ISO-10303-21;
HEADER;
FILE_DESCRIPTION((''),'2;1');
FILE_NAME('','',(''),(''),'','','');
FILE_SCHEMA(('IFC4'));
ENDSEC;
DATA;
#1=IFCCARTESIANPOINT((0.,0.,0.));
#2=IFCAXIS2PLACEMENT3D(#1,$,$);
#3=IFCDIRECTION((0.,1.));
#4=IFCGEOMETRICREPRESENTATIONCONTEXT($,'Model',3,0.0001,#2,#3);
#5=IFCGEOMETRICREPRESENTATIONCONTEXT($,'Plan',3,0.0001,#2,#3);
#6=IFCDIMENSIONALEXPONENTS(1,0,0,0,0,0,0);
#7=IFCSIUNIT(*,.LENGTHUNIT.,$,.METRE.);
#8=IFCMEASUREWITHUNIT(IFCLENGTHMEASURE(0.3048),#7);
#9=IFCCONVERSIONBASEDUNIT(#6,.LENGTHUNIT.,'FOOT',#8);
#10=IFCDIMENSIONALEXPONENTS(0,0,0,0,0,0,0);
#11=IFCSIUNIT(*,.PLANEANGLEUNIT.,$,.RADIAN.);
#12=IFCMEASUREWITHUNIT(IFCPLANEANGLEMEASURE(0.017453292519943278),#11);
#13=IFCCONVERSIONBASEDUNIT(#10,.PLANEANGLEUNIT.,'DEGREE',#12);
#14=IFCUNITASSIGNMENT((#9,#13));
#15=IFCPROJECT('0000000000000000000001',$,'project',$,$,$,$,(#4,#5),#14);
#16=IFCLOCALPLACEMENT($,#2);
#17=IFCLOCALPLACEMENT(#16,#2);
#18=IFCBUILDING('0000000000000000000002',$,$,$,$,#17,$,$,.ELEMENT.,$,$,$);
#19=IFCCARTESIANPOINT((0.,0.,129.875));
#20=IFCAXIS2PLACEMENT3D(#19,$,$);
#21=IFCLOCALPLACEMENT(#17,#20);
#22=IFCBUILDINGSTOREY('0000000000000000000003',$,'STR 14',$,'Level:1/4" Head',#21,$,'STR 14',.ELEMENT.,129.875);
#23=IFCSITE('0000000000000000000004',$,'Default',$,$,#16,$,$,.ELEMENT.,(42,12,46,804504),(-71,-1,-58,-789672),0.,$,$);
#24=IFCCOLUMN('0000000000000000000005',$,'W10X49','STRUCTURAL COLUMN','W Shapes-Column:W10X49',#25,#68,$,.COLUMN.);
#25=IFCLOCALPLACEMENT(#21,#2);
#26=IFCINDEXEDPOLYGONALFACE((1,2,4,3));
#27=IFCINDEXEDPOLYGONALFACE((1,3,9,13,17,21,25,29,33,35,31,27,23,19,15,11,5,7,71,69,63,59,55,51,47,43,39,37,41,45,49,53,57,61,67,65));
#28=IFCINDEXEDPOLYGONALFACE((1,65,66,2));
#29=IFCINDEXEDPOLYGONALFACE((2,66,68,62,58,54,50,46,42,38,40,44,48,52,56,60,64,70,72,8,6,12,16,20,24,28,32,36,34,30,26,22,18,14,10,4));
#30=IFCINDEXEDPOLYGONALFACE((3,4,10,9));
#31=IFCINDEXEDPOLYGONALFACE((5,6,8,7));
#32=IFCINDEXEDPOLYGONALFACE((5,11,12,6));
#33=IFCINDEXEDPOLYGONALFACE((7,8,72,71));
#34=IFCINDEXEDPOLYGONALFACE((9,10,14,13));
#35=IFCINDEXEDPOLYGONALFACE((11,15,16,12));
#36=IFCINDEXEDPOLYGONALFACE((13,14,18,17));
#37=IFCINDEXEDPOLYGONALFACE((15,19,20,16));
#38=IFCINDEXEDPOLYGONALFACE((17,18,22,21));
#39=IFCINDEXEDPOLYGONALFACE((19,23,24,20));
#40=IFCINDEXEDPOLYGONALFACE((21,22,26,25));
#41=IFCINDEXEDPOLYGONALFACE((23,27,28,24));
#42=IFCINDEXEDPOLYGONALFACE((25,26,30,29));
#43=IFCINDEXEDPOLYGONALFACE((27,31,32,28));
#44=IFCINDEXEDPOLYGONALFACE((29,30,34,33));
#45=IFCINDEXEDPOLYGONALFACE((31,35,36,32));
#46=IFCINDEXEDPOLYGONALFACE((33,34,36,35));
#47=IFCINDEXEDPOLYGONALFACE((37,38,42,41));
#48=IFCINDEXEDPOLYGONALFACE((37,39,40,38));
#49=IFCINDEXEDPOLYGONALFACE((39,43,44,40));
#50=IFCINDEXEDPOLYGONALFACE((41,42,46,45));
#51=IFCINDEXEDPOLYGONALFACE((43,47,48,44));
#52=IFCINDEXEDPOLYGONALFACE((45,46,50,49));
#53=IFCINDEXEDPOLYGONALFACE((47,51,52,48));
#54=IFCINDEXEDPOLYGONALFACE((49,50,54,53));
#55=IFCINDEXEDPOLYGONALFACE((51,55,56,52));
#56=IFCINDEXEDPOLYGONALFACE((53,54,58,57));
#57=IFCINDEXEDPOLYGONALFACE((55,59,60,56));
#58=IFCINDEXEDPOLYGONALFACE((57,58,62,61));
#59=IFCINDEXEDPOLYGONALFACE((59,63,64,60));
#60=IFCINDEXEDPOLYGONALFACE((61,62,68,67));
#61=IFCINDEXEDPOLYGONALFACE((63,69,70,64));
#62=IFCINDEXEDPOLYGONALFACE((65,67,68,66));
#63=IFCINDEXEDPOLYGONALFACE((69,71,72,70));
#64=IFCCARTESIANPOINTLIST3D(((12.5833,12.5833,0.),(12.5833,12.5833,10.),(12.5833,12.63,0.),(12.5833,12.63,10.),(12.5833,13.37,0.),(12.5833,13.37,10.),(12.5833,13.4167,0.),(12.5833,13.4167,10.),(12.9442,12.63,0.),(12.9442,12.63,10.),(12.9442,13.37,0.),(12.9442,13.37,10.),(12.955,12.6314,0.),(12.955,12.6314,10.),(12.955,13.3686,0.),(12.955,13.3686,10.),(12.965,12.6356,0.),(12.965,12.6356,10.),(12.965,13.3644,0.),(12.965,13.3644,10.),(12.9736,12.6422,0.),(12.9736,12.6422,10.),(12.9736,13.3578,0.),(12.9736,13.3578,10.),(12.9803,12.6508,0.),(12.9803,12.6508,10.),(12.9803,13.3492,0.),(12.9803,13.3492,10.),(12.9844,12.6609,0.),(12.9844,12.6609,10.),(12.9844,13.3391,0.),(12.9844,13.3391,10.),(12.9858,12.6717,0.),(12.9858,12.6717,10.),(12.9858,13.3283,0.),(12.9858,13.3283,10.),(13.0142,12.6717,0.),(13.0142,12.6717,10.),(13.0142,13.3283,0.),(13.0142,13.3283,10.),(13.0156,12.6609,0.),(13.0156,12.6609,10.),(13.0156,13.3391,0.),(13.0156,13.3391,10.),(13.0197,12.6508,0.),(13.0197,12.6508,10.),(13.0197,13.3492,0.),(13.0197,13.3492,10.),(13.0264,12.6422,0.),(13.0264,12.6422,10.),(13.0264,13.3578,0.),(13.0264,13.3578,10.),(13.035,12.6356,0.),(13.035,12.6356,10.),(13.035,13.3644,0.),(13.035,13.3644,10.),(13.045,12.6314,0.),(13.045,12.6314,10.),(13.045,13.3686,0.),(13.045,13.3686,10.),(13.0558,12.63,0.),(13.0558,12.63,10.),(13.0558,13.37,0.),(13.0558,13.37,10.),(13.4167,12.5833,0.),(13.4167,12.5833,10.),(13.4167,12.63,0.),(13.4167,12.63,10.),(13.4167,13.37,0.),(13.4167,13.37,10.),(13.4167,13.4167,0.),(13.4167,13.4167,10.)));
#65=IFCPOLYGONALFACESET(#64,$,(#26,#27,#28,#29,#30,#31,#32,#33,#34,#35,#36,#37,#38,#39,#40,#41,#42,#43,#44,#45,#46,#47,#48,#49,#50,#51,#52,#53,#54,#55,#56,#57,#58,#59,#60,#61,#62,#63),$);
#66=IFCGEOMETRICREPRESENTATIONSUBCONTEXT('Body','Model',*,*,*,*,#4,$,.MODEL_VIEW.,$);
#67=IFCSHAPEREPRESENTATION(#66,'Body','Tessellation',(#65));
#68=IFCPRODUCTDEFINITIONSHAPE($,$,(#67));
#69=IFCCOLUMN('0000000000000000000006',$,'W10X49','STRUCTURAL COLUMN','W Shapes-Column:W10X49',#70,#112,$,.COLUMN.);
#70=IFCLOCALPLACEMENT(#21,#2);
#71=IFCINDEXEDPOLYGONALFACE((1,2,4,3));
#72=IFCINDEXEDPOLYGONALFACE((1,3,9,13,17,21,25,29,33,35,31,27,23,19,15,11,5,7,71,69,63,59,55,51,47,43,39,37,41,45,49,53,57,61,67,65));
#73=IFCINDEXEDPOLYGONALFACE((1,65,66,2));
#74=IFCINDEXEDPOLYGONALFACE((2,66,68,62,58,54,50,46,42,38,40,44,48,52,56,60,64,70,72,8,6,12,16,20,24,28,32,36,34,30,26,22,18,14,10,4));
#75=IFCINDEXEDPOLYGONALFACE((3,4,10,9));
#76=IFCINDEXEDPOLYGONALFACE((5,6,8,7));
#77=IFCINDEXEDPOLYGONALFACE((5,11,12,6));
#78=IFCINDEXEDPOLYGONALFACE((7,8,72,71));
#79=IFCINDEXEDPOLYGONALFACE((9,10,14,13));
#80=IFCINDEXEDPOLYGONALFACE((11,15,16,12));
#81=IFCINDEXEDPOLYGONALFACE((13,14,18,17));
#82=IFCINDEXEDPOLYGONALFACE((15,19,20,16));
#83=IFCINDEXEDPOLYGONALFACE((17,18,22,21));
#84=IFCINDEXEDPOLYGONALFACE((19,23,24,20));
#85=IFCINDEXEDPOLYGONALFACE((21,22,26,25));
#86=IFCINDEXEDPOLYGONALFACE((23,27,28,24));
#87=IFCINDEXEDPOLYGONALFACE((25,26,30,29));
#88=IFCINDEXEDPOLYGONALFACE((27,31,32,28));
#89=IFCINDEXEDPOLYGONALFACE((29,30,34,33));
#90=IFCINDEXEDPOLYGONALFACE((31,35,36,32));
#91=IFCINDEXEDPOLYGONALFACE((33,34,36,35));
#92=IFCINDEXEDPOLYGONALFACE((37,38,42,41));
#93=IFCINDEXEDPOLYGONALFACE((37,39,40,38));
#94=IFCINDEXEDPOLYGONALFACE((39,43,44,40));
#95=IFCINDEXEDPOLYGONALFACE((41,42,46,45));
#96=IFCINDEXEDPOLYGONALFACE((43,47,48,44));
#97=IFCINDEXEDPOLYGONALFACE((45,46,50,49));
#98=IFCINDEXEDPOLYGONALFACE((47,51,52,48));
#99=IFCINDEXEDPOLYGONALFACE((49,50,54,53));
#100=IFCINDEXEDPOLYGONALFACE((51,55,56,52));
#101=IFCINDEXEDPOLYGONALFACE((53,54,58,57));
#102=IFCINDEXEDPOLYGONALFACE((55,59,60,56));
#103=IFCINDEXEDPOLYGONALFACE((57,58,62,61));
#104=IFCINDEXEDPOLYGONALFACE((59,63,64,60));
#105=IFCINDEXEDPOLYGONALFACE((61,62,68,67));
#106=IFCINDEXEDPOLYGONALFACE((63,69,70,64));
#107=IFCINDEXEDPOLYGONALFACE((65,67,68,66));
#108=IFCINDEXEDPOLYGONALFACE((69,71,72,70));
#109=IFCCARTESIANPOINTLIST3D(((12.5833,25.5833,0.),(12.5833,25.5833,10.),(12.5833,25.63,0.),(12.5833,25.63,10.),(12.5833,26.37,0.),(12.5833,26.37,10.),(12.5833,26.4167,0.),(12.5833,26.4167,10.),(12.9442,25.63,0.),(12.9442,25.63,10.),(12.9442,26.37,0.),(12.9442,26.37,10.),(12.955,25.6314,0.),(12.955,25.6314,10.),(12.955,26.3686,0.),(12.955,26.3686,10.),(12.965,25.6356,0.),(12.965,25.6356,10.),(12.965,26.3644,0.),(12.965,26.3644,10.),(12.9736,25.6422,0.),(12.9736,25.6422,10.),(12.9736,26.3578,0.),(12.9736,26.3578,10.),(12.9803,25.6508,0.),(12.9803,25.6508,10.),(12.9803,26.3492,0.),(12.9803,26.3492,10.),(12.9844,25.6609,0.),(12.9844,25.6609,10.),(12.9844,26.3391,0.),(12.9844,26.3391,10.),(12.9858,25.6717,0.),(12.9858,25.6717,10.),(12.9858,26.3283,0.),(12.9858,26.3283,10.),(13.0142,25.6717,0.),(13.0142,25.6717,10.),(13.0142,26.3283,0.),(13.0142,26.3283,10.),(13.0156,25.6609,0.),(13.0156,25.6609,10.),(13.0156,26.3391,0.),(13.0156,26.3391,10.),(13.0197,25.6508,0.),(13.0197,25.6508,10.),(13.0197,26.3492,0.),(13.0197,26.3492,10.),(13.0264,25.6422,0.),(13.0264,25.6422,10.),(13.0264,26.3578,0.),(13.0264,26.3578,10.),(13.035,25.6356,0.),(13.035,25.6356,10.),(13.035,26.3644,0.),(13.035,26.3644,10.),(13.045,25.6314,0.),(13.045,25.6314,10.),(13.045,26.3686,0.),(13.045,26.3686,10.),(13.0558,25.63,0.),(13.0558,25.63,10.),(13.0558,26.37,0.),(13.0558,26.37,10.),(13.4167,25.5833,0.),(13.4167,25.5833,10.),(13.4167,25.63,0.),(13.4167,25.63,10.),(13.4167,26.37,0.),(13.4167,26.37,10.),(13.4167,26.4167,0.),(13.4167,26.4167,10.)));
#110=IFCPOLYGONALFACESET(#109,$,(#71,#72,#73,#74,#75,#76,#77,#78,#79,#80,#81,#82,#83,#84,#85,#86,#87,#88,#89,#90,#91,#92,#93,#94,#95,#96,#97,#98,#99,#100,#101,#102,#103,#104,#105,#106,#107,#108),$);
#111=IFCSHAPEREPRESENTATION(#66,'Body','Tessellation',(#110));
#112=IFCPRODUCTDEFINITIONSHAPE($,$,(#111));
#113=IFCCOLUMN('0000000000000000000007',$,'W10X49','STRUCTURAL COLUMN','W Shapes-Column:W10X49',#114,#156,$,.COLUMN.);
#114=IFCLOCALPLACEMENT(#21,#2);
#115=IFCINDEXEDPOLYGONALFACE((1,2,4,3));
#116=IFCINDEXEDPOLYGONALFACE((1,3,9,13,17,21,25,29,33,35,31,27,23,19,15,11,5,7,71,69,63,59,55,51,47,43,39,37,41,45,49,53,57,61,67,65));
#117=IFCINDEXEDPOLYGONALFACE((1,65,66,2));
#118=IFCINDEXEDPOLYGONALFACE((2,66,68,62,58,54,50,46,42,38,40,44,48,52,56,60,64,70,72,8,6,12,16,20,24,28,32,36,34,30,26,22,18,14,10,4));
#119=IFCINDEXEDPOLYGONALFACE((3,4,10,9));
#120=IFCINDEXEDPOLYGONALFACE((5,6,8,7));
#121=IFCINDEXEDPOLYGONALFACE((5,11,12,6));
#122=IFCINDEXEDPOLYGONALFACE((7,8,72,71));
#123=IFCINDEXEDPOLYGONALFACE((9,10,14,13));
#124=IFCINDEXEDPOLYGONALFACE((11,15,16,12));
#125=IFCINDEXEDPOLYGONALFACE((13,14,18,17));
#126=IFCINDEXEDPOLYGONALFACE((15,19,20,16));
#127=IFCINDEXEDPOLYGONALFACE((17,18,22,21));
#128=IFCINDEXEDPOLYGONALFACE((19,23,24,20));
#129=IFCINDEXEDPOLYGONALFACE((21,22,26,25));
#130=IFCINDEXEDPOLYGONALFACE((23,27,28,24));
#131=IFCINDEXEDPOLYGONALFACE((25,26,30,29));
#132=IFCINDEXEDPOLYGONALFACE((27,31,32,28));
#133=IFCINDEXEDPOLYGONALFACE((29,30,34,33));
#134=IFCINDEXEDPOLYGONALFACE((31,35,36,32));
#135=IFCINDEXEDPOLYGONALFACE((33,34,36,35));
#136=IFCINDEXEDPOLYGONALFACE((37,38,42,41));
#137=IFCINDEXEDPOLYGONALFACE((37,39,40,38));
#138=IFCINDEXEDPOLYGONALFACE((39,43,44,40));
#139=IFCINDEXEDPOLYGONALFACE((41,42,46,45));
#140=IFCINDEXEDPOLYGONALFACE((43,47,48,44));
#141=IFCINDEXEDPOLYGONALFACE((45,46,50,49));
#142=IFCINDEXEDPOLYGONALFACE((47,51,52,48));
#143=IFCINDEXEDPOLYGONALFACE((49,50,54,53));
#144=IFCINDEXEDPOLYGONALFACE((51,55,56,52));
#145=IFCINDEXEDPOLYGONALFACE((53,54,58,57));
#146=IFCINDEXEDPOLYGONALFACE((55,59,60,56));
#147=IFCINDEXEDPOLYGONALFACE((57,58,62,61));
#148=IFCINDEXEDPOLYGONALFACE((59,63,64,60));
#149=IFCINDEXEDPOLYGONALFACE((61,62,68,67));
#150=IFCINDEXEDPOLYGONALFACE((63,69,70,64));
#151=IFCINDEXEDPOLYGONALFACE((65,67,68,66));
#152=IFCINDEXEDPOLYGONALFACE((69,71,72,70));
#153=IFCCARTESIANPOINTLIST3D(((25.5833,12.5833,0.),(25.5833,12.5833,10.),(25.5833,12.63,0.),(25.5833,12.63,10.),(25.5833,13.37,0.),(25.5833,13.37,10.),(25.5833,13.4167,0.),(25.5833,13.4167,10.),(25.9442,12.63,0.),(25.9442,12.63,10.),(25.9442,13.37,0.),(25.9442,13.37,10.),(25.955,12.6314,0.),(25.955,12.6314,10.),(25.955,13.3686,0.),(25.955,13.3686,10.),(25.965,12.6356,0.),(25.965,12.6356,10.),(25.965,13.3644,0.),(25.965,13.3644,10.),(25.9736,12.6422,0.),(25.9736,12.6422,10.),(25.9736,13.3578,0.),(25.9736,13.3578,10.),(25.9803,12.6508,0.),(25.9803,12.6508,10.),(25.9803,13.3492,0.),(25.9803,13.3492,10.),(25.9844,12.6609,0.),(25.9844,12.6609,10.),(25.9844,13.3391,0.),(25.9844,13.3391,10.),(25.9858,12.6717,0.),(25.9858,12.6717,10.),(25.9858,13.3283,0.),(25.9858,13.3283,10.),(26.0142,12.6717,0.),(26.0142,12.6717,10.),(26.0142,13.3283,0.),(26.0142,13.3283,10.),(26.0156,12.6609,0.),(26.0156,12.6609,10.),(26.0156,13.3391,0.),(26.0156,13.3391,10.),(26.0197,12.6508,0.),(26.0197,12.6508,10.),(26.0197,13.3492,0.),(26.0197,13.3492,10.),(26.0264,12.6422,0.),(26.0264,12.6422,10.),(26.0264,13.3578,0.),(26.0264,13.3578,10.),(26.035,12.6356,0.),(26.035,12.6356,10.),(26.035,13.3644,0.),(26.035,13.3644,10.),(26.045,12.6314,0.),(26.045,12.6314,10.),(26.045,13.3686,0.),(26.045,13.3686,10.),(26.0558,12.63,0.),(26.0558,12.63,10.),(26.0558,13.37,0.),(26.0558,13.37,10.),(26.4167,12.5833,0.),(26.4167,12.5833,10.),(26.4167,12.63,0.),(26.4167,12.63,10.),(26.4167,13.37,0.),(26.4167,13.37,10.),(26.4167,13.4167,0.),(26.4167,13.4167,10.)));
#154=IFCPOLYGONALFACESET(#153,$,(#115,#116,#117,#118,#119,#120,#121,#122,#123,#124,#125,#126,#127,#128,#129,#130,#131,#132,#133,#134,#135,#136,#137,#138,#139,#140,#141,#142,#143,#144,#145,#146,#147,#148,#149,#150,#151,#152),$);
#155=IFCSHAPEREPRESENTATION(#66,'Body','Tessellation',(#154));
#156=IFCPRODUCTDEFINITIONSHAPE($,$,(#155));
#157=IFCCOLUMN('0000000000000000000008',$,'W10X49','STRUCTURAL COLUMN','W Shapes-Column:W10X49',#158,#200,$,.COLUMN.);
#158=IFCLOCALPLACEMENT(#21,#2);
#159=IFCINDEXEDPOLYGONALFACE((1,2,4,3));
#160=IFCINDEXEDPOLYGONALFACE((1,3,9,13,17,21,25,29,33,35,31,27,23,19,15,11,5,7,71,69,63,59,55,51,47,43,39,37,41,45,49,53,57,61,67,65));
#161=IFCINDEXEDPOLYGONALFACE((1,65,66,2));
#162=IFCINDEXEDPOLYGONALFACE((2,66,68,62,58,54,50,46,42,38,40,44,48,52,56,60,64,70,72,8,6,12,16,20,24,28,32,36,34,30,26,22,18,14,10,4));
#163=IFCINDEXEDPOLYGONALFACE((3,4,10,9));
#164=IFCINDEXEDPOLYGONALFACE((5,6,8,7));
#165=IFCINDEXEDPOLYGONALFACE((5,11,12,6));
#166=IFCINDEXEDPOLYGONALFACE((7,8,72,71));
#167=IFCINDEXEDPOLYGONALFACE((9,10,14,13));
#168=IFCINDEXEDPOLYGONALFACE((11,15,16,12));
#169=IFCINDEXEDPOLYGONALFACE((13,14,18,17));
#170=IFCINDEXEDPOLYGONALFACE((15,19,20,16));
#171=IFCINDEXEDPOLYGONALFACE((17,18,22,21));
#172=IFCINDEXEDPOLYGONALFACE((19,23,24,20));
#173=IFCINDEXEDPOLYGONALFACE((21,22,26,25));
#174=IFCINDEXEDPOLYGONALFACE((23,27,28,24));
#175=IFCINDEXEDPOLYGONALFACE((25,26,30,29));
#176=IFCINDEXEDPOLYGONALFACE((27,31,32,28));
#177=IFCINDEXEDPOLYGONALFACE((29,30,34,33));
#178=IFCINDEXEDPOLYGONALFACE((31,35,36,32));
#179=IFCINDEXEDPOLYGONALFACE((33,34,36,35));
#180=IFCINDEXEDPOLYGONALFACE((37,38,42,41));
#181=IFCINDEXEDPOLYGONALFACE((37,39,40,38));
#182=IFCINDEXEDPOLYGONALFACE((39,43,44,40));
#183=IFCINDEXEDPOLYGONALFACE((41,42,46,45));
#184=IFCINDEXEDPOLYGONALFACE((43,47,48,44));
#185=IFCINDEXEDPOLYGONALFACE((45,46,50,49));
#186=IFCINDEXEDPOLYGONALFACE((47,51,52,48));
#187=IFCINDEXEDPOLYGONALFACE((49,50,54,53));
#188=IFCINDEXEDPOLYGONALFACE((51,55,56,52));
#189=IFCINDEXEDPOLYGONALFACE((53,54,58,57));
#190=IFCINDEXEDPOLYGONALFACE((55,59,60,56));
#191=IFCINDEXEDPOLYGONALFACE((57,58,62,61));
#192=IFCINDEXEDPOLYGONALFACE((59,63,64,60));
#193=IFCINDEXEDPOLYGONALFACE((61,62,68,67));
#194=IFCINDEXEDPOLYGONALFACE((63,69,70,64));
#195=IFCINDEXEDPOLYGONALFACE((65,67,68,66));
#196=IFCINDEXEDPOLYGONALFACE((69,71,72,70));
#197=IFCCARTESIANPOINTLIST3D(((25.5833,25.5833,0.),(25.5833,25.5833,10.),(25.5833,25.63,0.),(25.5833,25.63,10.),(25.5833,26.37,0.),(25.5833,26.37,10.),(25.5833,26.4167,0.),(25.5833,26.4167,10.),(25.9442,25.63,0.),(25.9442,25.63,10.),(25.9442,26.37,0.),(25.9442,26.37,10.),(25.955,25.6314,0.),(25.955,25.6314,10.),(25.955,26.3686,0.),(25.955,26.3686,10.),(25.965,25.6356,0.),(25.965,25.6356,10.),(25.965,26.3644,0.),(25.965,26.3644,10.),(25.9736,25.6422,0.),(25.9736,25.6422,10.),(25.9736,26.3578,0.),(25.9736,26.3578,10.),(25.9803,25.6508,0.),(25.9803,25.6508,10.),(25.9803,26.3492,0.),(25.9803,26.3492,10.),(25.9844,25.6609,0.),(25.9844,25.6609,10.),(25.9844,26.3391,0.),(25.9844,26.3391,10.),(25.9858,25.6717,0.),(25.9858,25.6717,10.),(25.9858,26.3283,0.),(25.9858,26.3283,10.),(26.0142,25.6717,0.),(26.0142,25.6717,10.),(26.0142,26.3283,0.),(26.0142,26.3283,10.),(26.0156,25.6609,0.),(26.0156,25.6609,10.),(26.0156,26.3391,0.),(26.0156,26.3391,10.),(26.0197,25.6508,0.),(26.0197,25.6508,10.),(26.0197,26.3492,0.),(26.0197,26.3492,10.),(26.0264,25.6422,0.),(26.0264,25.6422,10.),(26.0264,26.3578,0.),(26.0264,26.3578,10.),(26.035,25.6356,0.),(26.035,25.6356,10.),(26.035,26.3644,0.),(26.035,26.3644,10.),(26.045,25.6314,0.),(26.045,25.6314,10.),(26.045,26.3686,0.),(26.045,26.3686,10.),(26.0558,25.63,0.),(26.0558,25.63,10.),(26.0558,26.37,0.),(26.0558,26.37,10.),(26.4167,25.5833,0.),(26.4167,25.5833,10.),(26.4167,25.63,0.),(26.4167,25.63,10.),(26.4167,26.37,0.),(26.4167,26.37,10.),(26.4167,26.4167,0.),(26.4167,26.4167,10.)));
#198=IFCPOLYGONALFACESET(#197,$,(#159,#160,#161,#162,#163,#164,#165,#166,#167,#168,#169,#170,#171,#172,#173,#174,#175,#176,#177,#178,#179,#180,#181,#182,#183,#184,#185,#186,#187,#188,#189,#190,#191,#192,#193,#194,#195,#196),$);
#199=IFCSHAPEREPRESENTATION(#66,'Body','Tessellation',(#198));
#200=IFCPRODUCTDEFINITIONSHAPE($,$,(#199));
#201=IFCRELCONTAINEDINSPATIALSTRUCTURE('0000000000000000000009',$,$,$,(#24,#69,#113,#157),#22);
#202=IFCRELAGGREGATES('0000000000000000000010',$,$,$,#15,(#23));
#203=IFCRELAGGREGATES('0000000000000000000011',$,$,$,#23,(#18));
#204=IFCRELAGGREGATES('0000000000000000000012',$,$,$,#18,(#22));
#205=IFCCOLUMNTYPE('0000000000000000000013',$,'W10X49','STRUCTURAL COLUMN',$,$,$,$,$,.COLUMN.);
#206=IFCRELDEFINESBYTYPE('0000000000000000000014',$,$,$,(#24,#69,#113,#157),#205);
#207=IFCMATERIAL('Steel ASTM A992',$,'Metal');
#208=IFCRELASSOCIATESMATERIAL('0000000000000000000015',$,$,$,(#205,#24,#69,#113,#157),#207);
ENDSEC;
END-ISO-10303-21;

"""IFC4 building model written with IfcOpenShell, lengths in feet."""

from ifc_helpers import new_model, entity, si_unit, converted_unit, direction, frame, origin, place, context, subcontext, project, spatial, line, arc, indexed_curve, outline, extrude, source, transform, mapped, material, type_object, type_shapes, element, save


model = new_model("IFC4")

# Units and contexts
model_context = context("Model", 3, precision=0.0001, world=origin(), true_north=direction((0.0, 1.0)))
plan_context = context("Plan", 3, precision=0.0001, world=origin(), true_north=direction((0.0, 1.0)))
body_context = subcontext(model_context, "Body", "Model", "MODEL_VIEW")
ifc_project = project(units=[converted_unit("LENGTHUNIT", "FOOT", entity("IfcLengthMeasure", 0.3048), si_unit("LENGTHUNIT", "METRE"), dimensions=[1, 0, 0, 0, 0, 0, 0]), converted_unit("PLANEANGLEUNIT", "DEGREE", entity("IfcPlaneAngleMeasure", 0.017453292519943278), si_unit("PLANEANGLEUNIT", "RADIAN"), dimensions=[0, 0, 0, 0, 0, 0, 0])], contexts=[model_context, plan_context])

# Site, building, storey
site_placement = place(None, origin())
site = spatial("IfcSite", under=ifc_project, at=site_placement, Name="Default", CompositionType="ELEMENT", RefLatitude=(42, 12, 46, 804504), RefLongitude=(-71, -1, -58, -789672), RefElevation=0.0)
building_placement = place(site_placement, origin())
building = spatial("IfcBuilding", under=site, at=building_placement, CompositionType="ELEMENT")
storey_placement = place(building_placement, frame((0.0, 0.0, 129.875)))
storey = spatial("IfcBuildingStorey", under=building, at=storey_placement, Name="STR 14", ObjectType="Level:1/4\" Head", LongName="STR 14", CompositionType="ELEMENT", Elevation=129.875)

# Columns
ifc_material = material(Name="Steel ASTM A992", Category="Metal")
column_type = type_object("IfcColumnType", Name="W10X49", Description="STRUCTURAL COLUMN", PredefinedType="COLUMN", material=ifc_material)
shared_shape_1 = source(origin(), body_context, "Body", "SweptSolid", [
    extrude(outline(indexed_curve([(-0.4167, -0.4167), (0.4167, -0.4167), (0.4167, -0.37), (0.0558, -0.37), (0.0264, -0.3578), (0.0142, -0.3283), (0.0142, 0.3283), (0.0264, 0.3578), (0.0558, 0.37), (0.4167, 0.37), (0.4167, 0.4167), (-0.4167, 0.4167), (-0.4167, 0.37), (-0.0558, 0.37), (-0.0264, 0.3578), (-0.0142, 0.3283), (-0.0142, -0.3283), (-0.0264, -0.3578), (-0.0558, -0.37), (-0.4167, -0.37)], segments=[line(1, 2, 3, 4), arc(4, 5, 6), line(6, 7), arc(7, 8, 9), line(9, 10, 11, 12, 13, 14), arc(14, 15, 16), line(16, 17), arc(17, 18, 19), line(19, 20, 1)], self_intersect=False)), frame((0.0, 0.0, 129.875), z_axis=(0.0, 0.0, 1.0), x_axis=(-1.0, 0.0, 0.0)), (0.0, 0.0, 1.0), 10.0),
])
type_shapes(column_type, [shared_shape_1])
for number, where, z_axis, x_axis, name in (
    (1, (13.0, 13.0, -129.875), (0.0, 0.0, 1.0), (-1.0, 0.0, 0.0), "W10X49"),
    (2, (13.0, 26.0, -129.875), (0.0, 0.0, 1.0), (-1.0, 0.0, 0.0), "W10X49"),
    (3, (26.0, 13.0, -129.875), (0.0, 0.0, 1.0), (-1.0, 0.0, 0.0), "W10X49"),
    (4, (26.0, 26.0, -129.875), (0.0, 0.0, 1.0), (-1.0, 0.0, 0.0), "W10X49"),
):
    element("IfcColumn", number, at=place(storey_placement, frame(where, z_axis=z_axis, x_axis=x_axis)), inside=storey, type_object=column_type, material=ifc_material, Name=name, Description="STRUCTURAL COLUMN", ObjectType="W Shapes-Column:W10X49", PredefinedType="COLUMN", context=body_context, shape_type="MappedRepresentation", body=[
        mapped(shared_shape_1, transform((0.0, 0.0, 0.0), scale=1.0)),
    ])

save(model, "model.ifc")
